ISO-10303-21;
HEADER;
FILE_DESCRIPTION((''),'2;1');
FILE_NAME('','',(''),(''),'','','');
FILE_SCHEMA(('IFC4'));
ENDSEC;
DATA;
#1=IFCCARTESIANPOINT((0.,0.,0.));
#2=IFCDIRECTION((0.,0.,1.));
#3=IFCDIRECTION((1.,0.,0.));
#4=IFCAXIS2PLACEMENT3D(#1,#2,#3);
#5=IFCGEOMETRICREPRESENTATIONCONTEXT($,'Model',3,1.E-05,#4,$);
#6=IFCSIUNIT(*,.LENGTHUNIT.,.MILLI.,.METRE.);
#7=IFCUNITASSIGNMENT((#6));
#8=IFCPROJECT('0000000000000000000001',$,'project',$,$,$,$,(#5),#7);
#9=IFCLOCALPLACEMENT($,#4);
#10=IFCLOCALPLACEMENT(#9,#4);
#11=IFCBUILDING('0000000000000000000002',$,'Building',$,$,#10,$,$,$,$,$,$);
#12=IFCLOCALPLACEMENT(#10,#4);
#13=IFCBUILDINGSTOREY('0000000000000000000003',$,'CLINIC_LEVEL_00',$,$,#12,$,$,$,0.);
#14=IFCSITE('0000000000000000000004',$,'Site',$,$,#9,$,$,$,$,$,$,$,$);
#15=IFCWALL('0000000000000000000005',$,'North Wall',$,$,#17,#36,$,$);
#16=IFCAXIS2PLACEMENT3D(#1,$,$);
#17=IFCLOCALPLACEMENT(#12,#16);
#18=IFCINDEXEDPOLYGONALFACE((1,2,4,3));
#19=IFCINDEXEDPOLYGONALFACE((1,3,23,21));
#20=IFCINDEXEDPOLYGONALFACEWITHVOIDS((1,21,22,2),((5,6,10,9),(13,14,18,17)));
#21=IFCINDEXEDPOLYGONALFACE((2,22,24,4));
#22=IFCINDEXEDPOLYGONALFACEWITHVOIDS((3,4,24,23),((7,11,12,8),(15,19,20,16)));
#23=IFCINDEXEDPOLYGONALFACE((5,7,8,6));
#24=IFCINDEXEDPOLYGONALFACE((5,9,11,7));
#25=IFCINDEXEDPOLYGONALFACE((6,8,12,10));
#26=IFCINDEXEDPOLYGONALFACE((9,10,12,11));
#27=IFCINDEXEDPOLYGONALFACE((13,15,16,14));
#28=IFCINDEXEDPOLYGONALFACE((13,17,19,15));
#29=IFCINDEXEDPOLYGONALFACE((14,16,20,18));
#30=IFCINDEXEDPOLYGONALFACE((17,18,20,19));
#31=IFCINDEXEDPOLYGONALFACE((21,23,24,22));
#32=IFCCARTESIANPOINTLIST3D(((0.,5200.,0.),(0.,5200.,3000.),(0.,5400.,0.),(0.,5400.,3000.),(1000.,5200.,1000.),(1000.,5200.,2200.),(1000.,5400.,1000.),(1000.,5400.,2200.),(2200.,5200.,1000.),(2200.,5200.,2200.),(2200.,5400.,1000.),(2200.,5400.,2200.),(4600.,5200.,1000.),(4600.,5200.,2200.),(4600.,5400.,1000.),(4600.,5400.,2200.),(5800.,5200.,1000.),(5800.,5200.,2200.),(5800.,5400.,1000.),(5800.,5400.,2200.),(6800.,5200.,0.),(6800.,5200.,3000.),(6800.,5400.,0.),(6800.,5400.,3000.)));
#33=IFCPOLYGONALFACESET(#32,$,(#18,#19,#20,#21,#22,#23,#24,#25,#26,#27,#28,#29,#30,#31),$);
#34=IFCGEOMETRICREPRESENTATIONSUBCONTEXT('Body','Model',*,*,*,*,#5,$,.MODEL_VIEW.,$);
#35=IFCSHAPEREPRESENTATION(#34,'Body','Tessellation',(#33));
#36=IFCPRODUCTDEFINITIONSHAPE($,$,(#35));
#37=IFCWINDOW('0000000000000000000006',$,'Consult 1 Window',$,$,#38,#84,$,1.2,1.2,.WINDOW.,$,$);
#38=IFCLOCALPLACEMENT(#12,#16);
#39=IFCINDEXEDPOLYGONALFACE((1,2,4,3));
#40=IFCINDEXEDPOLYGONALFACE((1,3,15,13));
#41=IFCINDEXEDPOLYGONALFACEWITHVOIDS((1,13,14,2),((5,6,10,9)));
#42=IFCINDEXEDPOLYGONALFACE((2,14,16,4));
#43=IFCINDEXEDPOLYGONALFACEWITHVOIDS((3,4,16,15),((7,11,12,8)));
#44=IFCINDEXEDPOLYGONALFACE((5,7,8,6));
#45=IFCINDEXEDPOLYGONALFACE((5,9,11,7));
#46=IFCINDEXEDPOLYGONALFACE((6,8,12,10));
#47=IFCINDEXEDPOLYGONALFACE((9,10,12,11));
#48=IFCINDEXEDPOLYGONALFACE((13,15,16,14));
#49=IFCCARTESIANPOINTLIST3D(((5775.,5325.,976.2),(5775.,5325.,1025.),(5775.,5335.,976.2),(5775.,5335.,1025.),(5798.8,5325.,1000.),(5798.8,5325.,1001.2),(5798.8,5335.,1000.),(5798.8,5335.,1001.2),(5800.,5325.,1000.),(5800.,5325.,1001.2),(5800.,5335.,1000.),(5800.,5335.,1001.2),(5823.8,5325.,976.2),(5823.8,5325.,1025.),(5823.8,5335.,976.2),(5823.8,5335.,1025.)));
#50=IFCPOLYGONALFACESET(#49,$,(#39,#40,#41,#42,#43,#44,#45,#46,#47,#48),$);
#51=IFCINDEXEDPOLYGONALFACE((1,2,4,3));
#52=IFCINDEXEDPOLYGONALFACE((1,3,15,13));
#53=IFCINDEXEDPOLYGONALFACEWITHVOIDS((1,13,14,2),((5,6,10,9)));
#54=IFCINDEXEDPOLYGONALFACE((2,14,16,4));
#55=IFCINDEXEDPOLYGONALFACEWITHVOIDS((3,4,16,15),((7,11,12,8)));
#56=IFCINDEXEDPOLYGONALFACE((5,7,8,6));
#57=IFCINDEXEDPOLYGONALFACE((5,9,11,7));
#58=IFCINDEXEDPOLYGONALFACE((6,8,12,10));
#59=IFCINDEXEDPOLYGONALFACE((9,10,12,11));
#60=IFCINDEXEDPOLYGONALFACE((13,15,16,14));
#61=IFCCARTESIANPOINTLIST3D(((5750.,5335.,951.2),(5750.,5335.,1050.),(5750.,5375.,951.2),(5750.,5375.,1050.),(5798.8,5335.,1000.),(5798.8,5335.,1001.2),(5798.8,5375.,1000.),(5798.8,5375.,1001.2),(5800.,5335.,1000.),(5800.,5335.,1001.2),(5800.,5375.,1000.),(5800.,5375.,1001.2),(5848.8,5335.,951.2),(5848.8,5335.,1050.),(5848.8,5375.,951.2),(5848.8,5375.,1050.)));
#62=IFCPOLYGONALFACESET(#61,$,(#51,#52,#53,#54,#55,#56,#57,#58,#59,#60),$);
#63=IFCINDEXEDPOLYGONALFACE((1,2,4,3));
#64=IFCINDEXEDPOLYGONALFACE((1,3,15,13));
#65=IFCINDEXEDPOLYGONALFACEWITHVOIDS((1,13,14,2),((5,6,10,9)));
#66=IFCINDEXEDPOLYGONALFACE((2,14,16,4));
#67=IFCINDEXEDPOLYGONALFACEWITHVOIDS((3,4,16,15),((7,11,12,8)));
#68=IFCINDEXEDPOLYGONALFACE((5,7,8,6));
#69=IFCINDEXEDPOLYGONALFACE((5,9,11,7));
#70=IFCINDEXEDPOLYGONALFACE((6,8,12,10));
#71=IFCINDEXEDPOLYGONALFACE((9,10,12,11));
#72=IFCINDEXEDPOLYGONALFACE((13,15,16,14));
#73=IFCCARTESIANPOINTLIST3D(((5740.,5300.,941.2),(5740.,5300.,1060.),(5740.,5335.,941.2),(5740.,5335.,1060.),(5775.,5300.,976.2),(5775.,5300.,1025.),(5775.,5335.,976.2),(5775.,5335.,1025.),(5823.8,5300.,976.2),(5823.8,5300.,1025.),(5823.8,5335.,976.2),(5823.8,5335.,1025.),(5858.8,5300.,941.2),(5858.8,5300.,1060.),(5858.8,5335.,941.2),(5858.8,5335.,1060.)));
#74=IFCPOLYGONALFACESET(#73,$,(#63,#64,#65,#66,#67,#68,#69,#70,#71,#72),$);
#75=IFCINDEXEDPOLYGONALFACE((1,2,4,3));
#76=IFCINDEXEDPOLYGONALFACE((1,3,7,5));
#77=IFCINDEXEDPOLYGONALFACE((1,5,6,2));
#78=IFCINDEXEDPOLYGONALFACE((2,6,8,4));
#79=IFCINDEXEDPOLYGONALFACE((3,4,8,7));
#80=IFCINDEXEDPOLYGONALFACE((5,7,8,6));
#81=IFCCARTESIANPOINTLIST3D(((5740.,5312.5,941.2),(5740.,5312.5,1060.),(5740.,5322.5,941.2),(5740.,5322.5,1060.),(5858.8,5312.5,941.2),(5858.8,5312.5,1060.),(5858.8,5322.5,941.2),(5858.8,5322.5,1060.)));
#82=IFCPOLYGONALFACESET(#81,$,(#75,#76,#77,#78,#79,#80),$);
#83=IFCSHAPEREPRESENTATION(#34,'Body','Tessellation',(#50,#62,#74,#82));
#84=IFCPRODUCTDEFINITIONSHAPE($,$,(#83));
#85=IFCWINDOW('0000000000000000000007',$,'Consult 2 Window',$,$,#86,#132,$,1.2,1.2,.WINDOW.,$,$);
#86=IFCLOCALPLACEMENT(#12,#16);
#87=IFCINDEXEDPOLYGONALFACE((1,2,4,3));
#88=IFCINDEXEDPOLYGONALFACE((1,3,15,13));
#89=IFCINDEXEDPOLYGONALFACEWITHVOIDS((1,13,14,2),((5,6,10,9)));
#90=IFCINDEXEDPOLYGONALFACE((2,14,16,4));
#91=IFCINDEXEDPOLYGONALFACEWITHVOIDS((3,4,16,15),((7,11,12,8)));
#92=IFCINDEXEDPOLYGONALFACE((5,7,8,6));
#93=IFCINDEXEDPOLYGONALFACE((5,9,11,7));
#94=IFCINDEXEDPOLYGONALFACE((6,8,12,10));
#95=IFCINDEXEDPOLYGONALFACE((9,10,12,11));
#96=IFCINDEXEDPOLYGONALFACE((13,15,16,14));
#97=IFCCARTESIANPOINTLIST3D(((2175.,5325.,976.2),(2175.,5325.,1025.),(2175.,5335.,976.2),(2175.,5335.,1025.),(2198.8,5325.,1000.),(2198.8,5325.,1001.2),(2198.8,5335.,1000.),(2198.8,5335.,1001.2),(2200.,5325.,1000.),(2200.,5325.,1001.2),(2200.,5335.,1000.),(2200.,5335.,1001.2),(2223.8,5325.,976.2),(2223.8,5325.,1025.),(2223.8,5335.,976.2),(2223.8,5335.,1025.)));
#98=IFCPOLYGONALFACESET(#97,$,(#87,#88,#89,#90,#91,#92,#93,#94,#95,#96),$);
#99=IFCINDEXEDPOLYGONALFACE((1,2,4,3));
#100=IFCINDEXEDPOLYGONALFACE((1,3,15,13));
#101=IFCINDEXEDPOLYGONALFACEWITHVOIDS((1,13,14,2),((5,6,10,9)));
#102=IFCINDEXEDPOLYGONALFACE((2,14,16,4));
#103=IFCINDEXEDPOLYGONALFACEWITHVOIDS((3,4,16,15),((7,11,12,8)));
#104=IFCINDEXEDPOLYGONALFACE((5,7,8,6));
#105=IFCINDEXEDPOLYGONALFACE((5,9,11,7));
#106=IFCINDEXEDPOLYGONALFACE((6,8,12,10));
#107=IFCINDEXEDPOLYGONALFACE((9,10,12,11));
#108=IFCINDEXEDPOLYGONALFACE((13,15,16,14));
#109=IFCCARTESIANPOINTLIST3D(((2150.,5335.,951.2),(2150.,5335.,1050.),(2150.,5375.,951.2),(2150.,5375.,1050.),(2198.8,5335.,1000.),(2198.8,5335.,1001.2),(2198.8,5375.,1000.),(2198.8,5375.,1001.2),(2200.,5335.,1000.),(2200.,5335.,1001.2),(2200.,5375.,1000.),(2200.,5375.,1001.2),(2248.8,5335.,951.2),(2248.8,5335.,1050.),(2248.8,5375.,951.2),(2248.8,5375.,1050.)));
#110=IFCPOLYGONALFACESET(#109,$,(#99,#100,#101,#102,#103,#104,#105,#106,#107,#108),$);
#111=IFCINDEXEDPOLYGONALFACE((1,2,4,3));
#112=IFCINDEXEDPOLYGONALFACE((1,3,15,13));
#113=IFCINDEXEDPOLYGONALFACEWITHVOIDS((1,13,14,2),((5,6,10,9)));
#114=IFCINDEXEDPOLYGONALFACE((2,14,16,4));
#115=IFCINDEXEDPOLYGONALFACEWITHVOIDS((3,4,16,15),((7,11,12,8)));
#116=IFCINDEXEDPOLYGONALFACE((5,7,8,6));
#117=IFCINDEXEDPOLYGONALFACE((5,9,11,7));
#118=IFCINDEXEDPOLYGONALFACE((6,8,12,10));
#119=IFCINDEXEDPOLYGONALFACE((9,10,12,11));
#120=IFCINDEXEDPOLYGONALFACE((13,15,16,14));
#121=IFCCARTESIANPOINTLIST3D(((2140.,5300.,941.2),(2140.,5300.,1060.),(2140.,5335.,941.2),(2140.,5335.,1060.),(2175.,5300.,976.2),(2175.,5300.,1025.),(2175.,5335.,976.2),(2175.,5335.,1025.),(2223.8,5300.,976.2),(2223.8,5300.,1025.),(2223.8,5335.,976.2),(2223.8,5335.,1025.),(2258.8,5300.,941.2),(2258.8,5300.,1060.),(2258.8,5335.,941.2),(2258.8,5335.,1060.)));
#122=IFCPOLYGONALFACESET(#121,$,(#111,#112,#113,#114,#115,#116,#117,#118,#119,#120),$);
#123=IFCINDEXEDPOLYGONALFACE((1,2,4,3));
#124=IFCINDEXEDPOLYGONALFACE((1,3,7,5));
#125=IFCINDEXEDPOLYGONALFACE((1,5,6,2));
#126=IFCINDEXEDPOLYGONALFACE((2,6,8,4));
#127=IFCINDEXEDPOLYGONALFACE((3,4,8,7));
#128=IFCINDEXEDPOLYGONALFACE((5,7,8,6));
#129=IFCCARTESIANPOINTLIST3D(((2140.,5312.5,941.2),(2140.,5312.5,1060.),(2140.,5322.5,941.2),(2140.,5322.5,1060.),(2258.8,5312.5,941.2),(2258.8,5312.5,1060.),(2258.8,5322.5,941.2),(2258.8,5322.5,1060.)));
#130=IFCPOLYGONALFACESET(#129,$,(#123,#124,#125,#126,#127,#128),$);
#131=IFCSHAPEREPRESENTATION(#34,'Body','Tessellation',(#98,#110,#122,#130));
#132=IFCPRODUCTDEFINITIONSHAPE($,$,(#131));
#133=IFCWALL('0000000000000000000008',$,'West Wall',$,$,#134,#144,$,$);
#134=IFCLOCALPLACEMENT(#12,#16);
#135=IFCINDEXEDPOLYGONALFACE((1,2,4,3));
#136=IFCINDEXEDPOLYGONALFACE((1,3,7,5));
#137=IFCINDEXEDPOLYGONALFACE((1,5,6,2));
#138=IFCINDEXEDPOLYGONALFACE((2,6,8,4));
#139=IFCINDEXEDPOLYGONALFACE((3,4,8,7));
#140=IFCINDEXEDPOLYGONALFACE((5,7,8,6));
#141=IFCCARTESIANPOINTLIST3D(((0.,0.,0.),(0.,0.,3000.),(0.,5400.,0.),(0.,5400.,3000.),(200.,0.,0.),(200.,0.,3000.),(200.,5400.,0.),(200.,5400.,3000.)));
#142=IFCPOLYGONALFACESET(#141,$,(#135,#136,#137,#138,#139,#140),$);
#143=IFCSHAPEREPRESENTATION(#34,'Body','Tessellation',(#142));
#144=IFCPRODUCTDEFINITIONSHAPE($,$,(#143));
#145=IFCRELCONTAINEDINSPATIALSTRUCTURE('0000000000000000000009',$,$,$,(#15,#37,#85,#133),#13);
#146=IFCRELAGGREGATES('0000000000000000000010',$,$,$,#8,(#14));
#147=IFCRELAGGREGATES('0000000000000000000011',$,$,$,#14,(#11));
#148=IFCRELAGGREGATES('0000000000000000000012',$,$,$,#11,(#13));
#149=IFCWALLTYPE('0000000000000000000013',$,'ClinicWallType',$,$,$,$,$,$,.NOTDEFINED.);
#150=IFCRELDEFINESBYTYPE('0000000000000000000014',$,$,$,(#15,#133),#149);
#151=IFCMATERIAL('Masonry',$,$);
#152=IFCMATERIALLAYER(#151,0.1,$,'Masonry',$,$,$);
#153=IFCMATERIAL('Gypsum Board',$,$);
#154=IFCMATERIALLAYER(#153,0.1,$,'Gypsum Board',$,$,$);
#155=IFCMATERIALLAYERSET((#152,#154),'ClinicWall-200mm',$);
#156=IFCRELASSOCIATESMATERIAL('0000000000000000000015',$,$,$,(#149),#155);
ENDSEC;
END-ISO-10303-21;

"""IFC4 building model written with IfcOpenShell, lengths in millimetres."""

from ifc_helpers import new_model, si_unit, frame, origin_with_axes, place, context, subcontext, project, spatial, line, indexed_curve, outline, extrude, material, layer, layer_set, type_object, element, fill, save


model = new_model("IFC4")

# Units and contexts
model_context = context("Model", 3, precision=1e-05, world=origin_with_axes())
body_context = subcontext(model_context, "Body", "Model", "MODEL_VIEW")
ifc_project = project(units=[si_unit("LENGTHUNIT", "METRE", prefix="MILLI")], contexts=[model_context])

# Site, building, storey
site_placement = place(None, origin_with_axes())
site = spatial("IfcSite", under=ifc_project, at=site_placement, Name="Site")
building_placement = place(site_placement, origin_with_axes())
building = spatial("IfcBuilding", under=site, at=building_placement, Name="Building")
storey_placement = place(building_placement, origin_with_axes())
storey = spatial("IfcBuildingStorey", under=building, at=storey_placement, Name="CLINIC_LEVEL_00", Elevation=0.0)

# Shared definitions
ifc_material_1 = material(Name="Masonry")
ifc_layer_1 = layer(ifc_material_1, 0.1, Name="Masonry")
ifc_material_2 = material(Name="Gypsum Board")
ifc_layer_2 = layer(ifc_material_2, 0.1, Name="Gypsum Board")
ifc_layer_set_1 = layer_set([ifc_layer_1, ifc_layer_2], Name="ClinicWall-200mm")
wall_type = type_object("IfcWallType", Name="ClinicWallType", PredefinedType="NOTDEFINED", material=ifc_layer_set_1)

# Wall, openings, windows
wall_1_placement = place(storey_placement, frame((6800.0, 5400.0, 0.0), z_axis=(0.0, 0.0, 1.0), x_axis=(-1.0, 0.0, 0.0)))
wall_1 = element("IfcWall", 1, at=wall_1_placement, inside=storey, type_object=wall_type, Name="North Wall", context=body_context, shape_type="SweptSolid", body=[
    extrude(outline(indexed_curve([(0.0, 0.0), (0.0, 200.0), (6800.0, 200.0), (6800.0, 0.0), (0.0, 0.0)], self_intersect=False)), origin_with_axes(), (0.0, 0.0, 1.0), 3000.0),
])
opening_1_placement = place(wall_1_placement, frame((1000.0, -25.0, 1000.0), z_axis=(0.0, 0.0, 1.0), x_axis=(1.0, 0.0, 0.0)))
opening_1 = element("IfcOpeningElement", 2, at=opening_1_placement, cuts=wall_1, context=body_context, shape_type="SweptSolid", body=[
    extrude(outline(indexed_curve([(0.0, 0.0), (0.0, 250.0), (1200.0, 250.0), (1200.0, 0.0), (0.0, 0.0)], self_intersect=False)), origin_with_axes(), (0.0, 0.0, 1.0), 1200.0),
])
opening_2_placement = place(wall_1_placement, frame((4600.0, -25.0, 1000.0), z_axis=(0.0, 0.0, 1.0), x_axis=(1.0, 0.0, 0.0)))
opening_2 = element("IfcOpeningElement", 3, at=opening_2_placement, cuts=wall_1, context=body_context, shape_type="SweptSolid", body=[
    extrude(outline(indexed_curve([(0.0, 0.0), (0.0, 250.0), (1200.0, 250.0), (1200.0, 0.0), (0.0, 0.0)], self_intersect=False)), origin_with_axes(), (0.0, 0.0, 1.0), 1200.0),
])
window_1_placement = place(storey_placement, frame((5800.0, 5425.0, 1000.0), z_axis=(0.0, 0.0, 1.0), x_axis=(-1.0, 0.0, 0.0)))
window_1 = element("IfcWindow", 4, at=window_1_placement, inside=storey, Name="Consult 1 Window", OverallHeight=1.2, OverallWidth=1.2, PredefinedType="WINDOW", context=body_context, shape_type="SweptSolid", body=[
    extrude(outline(indexed_curve([(0.0, 0.0), (1.2, 0.0), (1.2, 1.2), (0.0, 1.2)], segments=[line(1, 2, 3, 4, 1)]), holes=[indexed_curve([(25.0, 25.0), (-23.8, 25.0), (-23.8, -23.8), (25.0, -23.8)], segments=[line(1, 2, 3, 4, 1)])]), frame((0.0, 90.0, 0.0), z_axis=(0.0, -1.0, 0.0), x_axis=(1.0, 0.0, 0.0)), (0.0, 0.0, -1.0), 10.0),
    extrude(outline(indexed_curve([(0.0, 0.0), (1.2, 0.0), (1.2, 1.2), (0.0, 1.2)], segments=[line(1, 2, 3, 4, 1)]), holes=[indexed_curve([(50.0, 50.0), (-48.8, 50.0), (-48.8, -48.8), (50.0, -48.8)], segments=[line(1, 2, 3, 4, 1)])]), frame((0.0, 50.0, 0.0), z_axis=(0.0, -1.0, 0.0), x_axis=(1.0, 0.0, 0.0)), (0.0, 0.0, -1.0), 40.0),
    extrude(outline(indexed_curve([(0.0, 0.0), (-48.8, 0.0), (-48.8, -48.8), (0.0, -48.8)], segments=[line(1, 2, 3, 4, 1)]), holes=[indexed_curve([(35.0, 35.0), (-83.8, 35.0), (-83.8, -83.8), (35.0, -83.8)], segments=[line(1, 2, 3, 4, 1)])]), frame((25.0, 90.0, 25.0), z_axis=(0.0, -1.0, 0.0), x_axis=(1.0, 0.0, 0.0)), (0.0, 0.0, -1.0), 35.0),
    extrude(outline(indexed_curve([(35.0, 35.0), (-83.8, 35.0), (-83.8, -83.8), (35.0, -83.8)], segments=[line(1, 2, 3, 4, 1)])), frame((25.0, 102.5, 25.0), z_axis=(0.0, -1.0, 0.0), x_axis=(1.0, 0.0, 0.0)), (0.0, 0.0, -1.0), 10.0),
])
fill(opening_1, window_1)
window_2_placement = place(storey_placement, frame((2200.0, 5425.0, 1000.0), z_axis=(0.0, 0.0, 1.0), x_axis=(-1.0, 0.0, 0.0)))
window_2 = element("IfcWindow", 5, at=window_2_placement, inside=storey, Name="Consult 2 Window", OverallHeight=1.2, OverallWidth=1.2, PredefinedType="WINDOW", context=body_context, shape_type="SweptSolid", body=[
    extrude(outline(indexed_curve([(0.0, 0.0), (1.2, 0.0), (1.2, 1.2), (0.0, 1.2)], segments=[line(1, 2, 3, 4, 1)]), holes=[indexed_curve([(25.0, 25.0), (-23.8, 25.0), (-23.8, -23.8), (25.0, -23.8)], segments=[line(1, 2, 3, 4, 1)])]), frame((0.0, 90.0, 0.0), z_axis=(0.0, -1.0, 0.0), x_axis=(1.0, 0.0, 0.0)), (0.0, 0.0, -1.0), 10.0),
    extrude(outline(indexed_curve([(0.0, 0.0), (1.2, 0.0), (1.2, 1.2), (0.0, 1.2)], segments=[line(1, 2, 3, 4, 1)]), holes=[indexed_curve([(50.0, 50.0), (-48.8, 50.0), (-48.8, -48.8), (50.0, -48.8)], segments=[line(1, 2, 3, 4, 1)])]), frame((0.0, 50.0, 0.0), z_axis=(0.0, -1.0, 0.0), x_axis=(1.0, 0.0, 0.0)), (0.0, 0.0, -1.0), 40.0),
    extrude(outline(indexed_curve([(0.0, 0.0), (-48.8, 0.0), (-48.8, -48.8), (0.0, -48.8)], segments=[line(1, 2, 3, 4, 1)]), holes=[indexed_curve([(35.0, 35.0), (-83.8, 35.0), (-83.8, -83.8), (35.0, -83.8)], segments=[line(1, 2, 3, 4, 1)])]), frame((25.0, 90.0, 25.0), z_axis=(0.0, -1.0, 0.0), x_axis=(1.0, 0.0, 0.0)), (0.0, 0.0, -1.0), 35.0),
    extrude(outline(indexed_curve([(35.0, 35.0), (-83.8, 35.0), (-83.8, -83.8), (35.0, -83.8)], segments=[line(1, 2, 3, 4, 1)])), frame((25.0, 102.5, 25.0), z_axis=(0.0, -1.0, 0.0), x_axis=(1.0, 0.0, 0.0)), (0.0, 0.0, -1.0), 10.0),
])
fill(opening_2, window_2)

# Wall
wall_2_placement = place(storey_placement, frame((0.0, 5400.0, 0.0), z_axis=(0.0, 0.0, 1.0), x_axis=(0.0, -1.0, 0.0)))
element("IfcWall", 6, at=wall_2_placement, inside=storey, type_object=wall_type, Name="West Wall", context=body_context, shape_type="SweptSolid", body=[
    extrude(outline(indexed_curve([(0.0, 0.0), (0.0, 200.0), (5400.0, 200.0), (5400.0, 0.0), (0.0, 0.0)], self_intersect=False)), origin_with_axes(), (0.0, 0.0, 1.0), 3000.0),
])

save(model, "model.ifc")
